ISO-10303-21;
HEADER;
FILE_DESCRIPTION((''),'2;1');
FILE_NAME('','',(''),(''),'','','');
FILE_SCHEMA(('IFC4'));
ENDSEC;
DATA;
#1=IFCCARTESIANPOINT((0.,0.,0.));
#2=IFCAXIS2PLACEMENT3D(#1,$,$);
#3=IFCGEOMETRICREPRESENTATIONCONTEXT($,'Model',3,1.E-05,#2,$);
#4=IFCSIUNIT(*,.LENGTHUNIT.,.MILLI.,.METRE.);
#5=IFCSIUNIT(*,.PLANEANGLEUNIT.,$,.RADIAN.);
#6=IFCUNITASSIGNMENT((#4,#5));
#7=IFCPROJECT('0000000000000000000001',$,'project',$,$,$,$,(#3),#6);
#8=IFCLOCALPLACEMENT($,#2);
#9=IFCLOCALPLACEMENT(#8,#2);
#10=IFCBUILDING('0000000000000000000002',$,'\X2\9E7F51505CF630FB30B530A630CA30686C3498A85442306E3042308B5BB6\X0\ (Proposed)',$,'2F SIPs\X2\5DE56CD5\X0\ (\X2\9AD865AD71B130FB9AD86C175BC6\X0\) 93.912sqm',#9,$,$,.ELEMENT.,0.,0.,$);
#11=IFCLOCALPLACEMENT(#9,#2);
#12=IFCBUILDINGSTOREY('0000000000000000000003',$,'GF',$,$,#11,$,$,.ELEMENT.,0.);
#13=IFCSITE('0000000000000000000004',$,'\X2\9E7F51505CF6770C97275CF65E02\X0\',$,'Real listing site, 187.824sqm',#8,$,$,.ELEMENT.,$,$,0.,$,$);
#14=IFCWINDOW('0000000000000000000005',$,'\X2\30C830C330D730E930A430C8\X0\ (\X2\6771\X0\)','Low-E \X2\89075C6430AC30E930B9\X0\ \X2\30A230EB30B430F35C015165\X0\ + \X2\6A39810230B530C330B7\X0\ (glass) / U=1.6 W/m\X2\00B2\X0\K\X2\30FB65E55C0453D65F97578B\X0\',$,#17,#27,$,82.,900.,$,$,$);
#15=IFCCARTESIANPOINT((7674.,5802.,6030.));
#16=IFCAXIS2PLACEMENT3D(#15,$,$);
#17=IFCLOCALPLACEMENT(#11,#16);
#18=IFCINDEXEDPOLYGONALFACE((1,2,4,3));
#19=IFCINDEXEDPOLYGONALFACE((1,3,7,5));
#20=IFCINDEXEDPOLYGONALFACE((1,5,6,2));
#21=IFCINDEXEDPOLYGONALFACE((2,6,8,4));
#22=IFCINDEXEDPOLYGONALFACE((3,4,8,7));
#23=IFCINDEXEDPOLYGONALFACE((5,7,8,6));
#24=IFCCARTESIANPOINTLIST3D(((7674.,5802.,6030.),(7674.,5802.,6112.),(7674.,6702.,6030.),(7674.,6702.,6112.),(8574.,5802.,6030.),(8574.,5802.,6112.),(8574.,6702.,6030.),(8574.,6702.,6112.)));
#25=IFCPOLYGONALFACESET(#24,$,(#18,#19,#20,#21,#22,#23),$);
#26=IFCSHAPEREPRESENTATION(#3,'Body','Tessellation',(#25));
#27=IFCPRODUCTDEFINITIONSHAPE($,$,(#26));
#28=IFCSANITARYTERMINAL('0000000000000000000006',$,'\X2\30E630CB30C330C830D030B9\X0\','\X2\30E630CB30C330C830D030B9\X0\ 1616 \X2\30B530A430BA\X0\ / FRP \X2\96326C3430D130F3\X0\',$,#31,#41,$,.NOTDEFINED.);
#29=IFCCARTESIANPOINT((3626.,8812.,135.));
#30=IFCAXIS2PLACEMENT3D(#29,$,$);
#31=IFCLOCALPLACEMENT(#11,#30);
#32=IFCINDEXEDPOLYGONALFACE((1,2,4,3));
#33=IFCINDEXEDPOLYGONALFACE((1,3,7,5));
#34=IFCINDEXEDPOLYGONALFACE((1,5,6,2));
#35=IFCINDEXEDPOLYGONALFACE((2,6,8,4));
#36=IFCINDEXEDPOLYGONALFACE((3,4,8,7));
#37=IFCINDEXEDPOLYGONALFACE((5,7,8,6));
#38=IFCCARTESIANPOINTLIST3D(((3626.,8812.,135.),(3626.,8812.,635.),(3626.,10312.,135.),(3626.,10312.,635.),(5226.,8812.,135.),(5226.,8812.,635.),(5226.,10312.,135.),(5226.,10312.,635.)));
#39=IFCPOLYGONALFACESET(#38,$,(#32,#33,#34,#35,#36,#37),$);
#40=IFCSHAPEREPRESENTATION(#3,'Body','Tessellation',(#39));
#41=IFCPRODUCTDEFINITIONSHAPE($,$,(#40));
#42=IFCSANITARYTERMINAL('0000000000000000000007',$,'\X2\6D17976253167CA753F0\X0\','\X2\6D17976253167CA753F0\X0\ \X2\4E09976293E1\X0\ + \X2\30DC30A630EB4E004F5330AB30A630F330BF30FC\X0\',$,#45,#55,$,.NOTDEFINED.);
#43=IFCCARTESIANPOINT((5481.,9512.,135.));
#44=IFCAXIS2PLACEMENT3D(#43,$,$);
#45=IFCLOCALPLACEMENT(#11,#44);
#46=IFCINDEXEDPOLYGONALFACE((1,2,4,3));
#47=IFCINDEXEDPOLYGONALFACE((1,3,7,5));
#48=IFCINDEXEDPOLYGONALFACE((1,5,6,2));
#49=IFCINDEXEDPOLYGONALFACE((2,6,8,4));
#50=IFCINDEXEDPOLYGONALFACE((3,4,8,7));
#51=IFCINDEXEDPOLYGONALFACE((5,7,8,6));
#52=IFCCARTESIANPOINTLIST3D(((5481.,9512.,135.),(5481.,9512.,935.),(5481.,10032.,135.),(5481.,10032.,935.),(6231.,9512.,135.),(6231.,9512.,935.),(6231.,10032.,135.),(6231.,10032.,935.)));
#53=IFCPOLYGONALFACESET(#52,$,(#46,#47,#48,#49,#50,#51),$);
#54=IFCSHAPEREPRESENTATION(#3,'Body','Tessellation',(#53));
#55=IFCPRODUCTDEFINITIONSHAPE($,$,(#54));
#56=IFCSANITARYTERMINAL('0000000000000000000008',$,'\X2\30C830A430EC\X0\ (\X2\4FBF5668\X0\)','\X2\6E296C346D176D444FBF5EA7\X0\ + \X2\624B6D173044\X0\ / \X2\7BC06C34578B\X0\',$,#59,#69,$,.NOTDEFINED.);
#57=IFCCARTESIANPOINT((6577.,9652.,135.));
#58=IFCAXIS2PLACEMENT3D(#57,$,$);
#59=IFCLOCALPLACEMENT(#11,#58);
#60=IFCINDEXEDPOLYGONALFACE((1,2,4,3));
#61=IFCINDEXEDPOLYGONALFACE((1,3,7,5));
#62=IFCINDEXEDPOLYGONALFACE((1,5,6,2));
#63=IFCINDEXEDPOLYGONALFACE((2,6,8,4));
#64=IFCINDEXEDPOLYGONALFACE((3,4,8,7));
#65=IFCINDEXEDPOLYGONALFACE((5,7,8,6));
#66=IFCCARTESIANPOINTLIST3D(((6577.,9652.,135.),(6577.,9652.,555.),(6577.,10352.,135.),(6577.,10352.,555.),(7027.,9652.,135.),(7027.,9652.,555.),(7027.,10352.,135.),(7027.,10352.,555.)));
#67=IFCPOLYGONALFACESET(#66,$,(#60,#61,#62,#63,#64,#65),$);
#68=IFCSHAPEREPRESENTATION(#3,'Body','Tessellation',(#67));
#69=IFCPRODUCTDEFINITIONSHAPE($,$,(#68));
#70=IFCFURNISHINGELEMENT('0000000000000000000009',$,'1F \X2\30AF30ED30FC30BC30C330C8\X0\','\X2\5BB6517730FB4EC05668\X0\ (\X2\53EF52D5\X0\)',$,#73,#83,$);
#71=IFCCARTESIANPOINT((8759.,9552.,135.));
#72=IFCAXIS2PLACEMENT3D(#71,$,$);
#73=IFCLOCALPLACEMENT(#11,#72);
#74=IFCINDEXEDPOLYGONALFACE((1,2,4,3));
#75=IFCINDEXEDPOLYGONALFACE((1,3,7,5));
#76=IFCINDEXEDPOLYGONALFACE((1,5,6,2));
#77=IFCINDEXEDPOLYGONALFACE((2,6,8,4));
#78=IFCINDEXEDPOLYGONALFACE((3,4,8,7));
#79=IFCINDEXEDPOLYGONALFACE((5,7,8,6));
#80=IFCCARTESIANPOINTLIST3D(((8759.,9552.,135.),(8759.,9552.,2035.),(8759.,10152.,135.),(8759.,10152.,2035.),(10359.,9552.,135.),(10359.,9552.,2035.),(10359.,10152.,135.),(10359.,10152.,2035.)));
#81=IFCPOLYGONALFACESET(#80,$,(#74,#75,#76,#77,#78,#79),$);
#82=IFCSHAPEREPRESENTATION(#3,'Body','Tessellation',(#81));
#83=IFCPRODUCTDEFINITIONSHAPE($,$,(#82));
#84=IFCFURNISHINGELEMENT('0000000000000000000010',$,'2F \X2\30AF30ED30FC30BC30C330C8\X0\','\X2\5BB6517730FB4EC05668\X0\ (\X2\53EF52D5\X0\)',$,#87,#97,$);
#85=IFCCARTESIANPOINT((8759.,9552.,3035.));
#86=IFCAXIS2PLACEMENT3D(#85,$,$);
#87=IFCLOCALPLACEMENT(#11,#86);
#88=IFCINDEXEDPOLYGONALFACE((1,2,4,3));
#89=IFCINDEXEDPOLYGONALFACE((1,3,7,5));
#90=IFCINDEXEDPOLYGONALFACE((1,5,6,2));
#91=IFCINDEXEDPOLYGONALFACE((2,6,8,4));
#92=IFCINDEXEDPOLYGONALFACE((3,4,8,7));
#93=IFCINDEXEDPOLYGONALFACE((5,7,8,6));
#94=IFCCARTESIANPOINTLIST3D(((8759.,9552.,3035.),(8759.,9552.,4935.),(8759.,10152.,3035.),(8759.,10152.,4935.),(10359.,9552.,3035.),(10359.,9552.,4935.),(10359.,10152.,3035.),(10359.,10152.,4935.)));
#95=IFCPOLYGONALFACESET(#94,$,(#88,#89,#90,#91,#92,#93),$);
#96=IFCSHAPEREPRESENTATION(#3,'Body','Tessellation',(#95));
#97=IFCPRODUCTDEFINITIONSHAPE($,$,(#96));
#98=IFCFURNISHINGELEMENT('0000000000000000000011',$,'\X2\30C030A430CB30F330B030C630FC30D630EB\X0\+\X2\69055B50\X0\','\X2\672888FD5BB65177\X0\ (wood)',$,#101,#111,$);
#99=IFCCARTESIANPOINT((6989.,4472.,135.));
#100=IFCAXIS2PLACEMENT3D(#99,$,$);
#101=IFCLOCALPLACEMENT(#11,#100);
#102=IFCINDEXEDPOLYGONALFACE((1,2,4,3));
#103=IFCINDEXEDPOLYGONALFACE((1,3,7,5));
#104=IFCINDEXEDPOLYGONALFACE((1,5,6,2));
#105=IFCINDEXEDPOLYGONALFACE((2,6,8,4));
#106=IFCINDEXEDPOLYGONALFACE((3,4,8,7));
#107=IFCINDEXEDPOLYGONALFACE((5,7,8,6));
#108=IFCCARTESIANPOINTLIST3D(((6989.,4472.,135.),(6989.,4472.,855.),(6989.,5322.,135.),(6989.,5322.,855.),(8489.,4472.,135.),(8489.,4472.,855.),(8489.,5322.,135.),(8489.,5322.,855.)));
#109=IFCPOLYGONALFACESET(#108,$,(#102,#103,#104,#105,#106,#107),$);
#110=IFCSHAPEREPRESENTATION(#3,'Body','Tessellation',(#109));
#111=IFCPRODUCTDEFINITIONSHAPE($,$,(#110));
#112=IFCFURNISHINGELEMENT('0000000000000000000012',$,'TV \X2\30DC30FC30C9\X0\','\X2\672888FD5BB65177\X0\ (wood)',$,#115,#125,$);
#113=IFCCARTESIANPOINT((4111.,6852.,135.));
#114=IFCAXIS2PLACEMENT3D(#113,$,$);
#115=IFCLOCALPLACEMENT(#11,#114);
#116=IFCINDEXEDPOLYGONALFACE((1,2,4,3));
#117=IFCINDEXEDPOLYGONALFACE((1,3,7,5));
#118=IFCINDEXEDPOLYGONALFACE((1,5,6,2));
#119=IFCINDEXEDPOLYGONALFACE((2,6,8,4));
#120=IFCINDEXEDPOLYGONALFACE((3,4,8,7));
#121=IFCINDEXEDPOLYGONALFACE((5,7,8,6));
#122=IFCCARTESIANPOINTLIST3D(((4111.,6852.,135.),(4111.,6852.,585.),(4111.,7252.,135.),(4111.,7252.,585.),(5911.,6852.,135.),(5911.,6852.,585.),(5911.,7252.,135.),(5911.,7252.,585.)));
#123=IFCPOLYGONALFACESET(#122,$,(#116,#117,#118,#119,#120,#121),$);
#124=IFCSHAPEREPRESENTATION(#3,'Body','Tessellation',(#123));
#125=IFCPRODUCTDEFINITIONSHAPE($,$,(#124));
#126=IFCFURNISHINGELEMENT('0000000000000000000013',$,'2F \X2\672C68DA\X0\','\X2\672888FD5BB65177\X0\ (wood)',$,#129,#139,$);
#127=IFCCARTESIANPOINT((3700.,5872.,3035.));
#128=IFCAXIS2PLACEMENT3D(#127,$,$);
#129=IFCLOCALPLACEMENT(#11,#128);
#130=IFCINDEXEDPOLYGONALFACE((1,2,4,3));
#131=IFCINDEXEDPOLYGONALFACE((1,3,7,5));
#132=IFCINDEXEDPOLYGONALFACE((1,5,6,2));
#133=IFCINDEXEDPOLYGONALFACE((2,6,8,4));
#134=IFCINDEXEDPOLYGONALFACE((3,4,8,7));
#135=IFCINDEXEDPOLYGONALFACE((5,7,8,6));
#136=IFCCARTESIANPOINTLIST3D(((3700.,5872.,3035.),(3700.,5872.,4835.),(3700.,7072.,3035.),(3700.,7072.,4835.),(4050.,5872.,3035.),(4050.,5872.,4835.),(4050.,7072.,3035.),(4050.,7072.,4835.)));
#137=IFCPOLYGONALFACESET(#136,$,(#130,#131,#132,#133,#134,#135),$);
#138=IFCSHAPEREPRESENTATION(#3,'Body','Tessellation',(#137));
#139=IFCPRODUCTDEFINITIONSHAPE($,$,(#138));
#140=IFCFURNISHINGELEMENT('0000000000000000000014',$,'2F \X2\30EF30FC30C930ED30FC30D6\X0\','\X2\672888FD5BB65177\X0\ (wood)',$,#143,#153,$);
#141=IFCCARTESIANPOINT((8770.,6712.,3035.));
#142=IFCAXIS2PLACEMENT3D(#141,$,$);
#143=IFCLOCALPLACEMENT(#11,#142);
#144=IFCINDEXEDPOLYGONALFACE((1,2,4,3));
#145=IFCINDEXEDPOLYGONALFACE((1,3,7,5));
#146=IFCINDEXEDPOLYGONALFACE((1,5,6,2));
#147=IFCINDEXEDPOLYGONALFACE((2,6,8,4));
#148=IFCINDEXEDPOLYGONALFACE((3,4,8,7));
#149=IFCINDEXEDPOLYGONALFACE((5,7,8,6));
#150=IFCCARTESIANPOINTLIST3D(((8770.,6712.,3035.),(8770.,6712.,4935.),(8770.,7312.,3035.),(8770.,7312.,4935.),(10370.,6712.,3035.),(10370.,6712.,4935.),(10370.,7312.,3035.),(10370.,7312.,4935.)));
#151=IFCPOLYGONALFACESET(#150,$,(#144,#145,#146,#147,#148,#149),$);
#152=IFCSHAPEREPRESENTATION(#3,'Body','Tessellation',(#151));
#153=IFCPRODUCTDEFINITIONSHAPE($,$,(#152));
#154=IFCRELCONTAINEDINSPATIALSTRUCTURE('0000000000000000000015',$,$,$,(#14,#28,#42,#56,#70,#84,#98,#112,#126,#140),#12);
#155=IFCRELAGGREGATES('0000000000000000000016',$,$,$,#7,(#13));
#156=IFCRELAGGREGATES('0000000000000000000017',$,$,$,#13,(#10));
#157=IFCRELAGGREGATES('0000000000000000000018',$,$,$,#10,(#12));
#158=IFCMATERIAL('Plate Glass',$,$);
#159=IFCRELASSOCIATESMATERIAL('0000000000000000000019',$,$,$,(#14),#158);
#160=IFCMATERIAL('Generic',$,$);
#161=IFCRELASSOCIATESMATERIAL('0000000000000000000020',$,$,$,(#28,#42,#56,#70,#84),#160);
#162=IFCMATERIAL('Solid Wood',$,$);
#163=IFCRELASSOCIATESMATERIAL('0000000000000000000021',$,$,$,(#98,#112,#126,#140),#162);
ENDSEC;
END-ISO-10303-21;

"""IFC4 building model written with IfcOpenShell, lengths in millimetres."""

from ifc_helpers import new_model, si_unit, frame, frame_2d, origin, place, context, project, spatial, rectangle, extrude, material, element, save


model = new_model("IFC4")

# Units and contexts
model_context = context("Model", 3, precision=1e-05, world=origin())
ifc_project = project(units=[si_unit("LENGTHUNIT", "METRE", prefix="MILLI"), si_unit("PLANEANGLEUNIT", "RADIAN")], contexts=[model_context])

# Site, building, storey
site_placement = place(None, origin())
site = spatial("IfcSite", under=ifc_project, at=site_placement, Name="鹿児島県霧島市", ObjectType="Real listing site, 187.824sqm", CompositionType="ELEMENT", RefElevation=0.0)
building_placement = place(site_placement, origin())
building = spatial("IfcBuilding", under=site, at=building_placement, Name="鹿児島・サウナと水風呂のある家 (Proposed)", ObjectType="2F SIPs工法 (高断熱・高気密) 93.912sqm", CompositionType="ELEMENT", ElevationOfRefHeight=0.0, ElevationOfTerrain=0.0)
storey_placement = place(building_placement, origin())
storey = spatial("IfcBuildingStorey", under=building, at=storey_placement, Name="GF", CompositionType="ELEMENT", Elevation=0.0)

# Shared definitions
ifc_material_1 = material(Name="Solid Wood")
ifc_material_2 = material(Name="Plate Glass")

# Window
window_1_placement = place(storey_placement, frame((7674.0, 5802.0, 6030.0)))
element("IfcWindow", 1, at=window_1_placement, inside=storey, material=ifc_material_2, Name="トップライト (東)", Description="Low-E 複層ガラス アルゴン封入 + 樹脂サッシ (glass) / U=1.6 W/m²K・日射取得型", OverallHeight=82.0, OverallWidth=900.0, context=model_context, shape_type="SweptSolid", body=[
    extrude(rectangle(XDim=900.0, YDim=900.0, at=frame_2d((450.0, 450.0))), frame((7674.0, 5802.0, 6030.0)), (0.0, 0.0, 1.0), 82.0),
])

# Sanitary terminals
ifc_material_3 = material(Name="Generic")
sanitary_terminal_1_placement = place(storey_placement, frame((3626.0, 8812.0, 135.0)))
element("IfcSanitaryTerminal", 2, at=sanitary_terminal_1_placement, inside=storey, material=ifc_material_3, Name="ユニットバス", Description="ユニットバス 1616 サイズ / FRP 防水パン", PredefinedType="NOTDEFINED", context=model_context, shape_type="SweptSolid", body=[
    extrude(rectangle(XDim=1600.0, YDim=1500.0, at=frame_2d((800.0, 750.0))), frame((3626.0, 8812.0, 135.0)), (0.0, 0.0, 1.0), 500.0),
])
sanitary_terminal_2_placement = place(storey_placement, frame((5481.0, 9512.0, 135.0)))
element("IfcSanitaryTerminal", 3, at=sanitary_terminal_2_placement, inside=storey, material=ifc_material_3, Name="洗面化粧台", Description="洗面化粧台 三面鏡 + ボウル一体カウンター", PredefinedType="NOTDEFINED", context=model_context, shape_type="SweptSolid", body=[
    extrude(rectangle(XDim=750.0, YDim=520.0, at=frame_2d((375.0, 260.0))), frame((5481.0, 9512.0, 135.0)), (0.0, 0.0, 1.0), 800.0),
])
sanitary_terminal_3_placement = place(storey_placement, frame((6577.0, 9652.0, 135.0)))
element("IfcSanitaryTerminal", 4, at=sanitary_terminal_3_placement, inside=storey, material=ifc_material_3, Name="トイレ (便器)", Description="温水洗浄便座 + 手洗い / 節水型", PredefinedType="NOTDEFINED", context=model_context, shape_type="SweptSolid", body=[
    extrude(rectangle(XDim=450.0, YDim=700.0, at=frame_2d((225.0, 350.0))), frame((6577.0, 9652.0, 135.0)), (0.0, 0.0, 1.0), 420.0),
])

# Furnishing elements
furnishing_1_placement = place(storey_placement, frame((8759.0, 9552.0, 135.0)))
element("IfcFurnishingElement", 5, at=furnishing_1_placement, inside=storey, material=ifc_material_3, Name="1F クローゼット", Description="家具・什器 (可動)", context=model_context, shape_type="SweptSolid", body=[
    extrude(rectangle(XDim=1600.0, YDim=600.0, at=frame_2d((800.0, 300.0))), frame((8759.0, 9552.0, 135.0)), (0.0, 0.0, 1.0), 1900.0),
])
furnishing_2_placement = place(storey_placement, frame((8759.0, 9552.0, 3035.0)))
element("IfcFurnishingElement", 6, at=furnishing_2_placement, inside=storey, material=ifc_material_3, Name="2F クローゼット", Description="家具・什器 (可動)", context=model_context, shape_type="SweptSolid", body=[
    extrude(rectangle(XDim=1600.0, YDim=600.0, at=frame_2d((800.0, 300.0))), frame((8759.0, 9552.0, 3035.0)), (0.0, 0.0, 1.0), 1900.0),
])
furnishing_3_placement = place(storey_placement, frame((6989.0, 4472.0, 135.0)))
element("IfcFurnishingElement", 7, at=furnishing_3_placement, inside=storey, material=ifc_material_1, Name="ダイニングテーブル+椅子", Description="木製家具 (wood)", context=model_context, shape_type="SweptSolid", body=[
    extrude(rectangle(XDim=1500.0, YDim=850.0, at=frame_2d((750.0, 425.0))), frame((6989.0, 4472.0, 135.0)), (0.0, 0.0, 1.0), 720.0),
])
furnishing_4_placement = place(storey_placement, frame((4111.0, 6852.0, 135.0)))
element("IfcFurnishingElement", 8, at=furnishing_4_placement, inside=storey, material=ifc_material_1, Name="TV ボード", Description="木製家具 (wood)", context=model_context, shape_type="SweptSolid", body=[
    extrude(rectangle(XDim=1800.0, YDim=400.0, at=frame_2d((900.0, 200.0))), frame((4111.0, 6852.0, 135.0)), (0.0, 0.0, 1.0), 450.0),
])
furnishing_5_placement = place(storey_placement, frame((3700.0, 5872.0, 3035.0)))
element("IfcFurnishingElement", 9, at=furnishing_5_placement, inside=storey, material=ifc_material_1, Name="2F 本棚", Description="木製家具 (wood)", context=model_context, shape_type="SweptSolid", body=[
    extrude(rectangle(XDim=350.0, YDim=1200.0, at=frame_2d((175.0, 600.0))), frame((3700.0, 5872.0, 3035.0)), (0.0, 0.0, 1.0), 1800.0),
])
furnishing_6_placement = place(storey_placement, frame((8770.0, 6712.0, 3035.0)))
element("IfcFurnishingElement", 10, at=furnishing_6_placement, inside=storey, material=ifc_material_1, Name="2F ワードローブ", Description="木製家具 (wood)", context=model_context, shape_type="SweptSolid", body=[
    extrude(rectangle(XDim=1600.0, YDim=600.0, at=frame_2d((800.0, 300.0))), frame((8770.0, 6712.0, 3035.0)), (0.0, 0.0, 1.0), 1900.0),
])

save(model, "model.ifc")
